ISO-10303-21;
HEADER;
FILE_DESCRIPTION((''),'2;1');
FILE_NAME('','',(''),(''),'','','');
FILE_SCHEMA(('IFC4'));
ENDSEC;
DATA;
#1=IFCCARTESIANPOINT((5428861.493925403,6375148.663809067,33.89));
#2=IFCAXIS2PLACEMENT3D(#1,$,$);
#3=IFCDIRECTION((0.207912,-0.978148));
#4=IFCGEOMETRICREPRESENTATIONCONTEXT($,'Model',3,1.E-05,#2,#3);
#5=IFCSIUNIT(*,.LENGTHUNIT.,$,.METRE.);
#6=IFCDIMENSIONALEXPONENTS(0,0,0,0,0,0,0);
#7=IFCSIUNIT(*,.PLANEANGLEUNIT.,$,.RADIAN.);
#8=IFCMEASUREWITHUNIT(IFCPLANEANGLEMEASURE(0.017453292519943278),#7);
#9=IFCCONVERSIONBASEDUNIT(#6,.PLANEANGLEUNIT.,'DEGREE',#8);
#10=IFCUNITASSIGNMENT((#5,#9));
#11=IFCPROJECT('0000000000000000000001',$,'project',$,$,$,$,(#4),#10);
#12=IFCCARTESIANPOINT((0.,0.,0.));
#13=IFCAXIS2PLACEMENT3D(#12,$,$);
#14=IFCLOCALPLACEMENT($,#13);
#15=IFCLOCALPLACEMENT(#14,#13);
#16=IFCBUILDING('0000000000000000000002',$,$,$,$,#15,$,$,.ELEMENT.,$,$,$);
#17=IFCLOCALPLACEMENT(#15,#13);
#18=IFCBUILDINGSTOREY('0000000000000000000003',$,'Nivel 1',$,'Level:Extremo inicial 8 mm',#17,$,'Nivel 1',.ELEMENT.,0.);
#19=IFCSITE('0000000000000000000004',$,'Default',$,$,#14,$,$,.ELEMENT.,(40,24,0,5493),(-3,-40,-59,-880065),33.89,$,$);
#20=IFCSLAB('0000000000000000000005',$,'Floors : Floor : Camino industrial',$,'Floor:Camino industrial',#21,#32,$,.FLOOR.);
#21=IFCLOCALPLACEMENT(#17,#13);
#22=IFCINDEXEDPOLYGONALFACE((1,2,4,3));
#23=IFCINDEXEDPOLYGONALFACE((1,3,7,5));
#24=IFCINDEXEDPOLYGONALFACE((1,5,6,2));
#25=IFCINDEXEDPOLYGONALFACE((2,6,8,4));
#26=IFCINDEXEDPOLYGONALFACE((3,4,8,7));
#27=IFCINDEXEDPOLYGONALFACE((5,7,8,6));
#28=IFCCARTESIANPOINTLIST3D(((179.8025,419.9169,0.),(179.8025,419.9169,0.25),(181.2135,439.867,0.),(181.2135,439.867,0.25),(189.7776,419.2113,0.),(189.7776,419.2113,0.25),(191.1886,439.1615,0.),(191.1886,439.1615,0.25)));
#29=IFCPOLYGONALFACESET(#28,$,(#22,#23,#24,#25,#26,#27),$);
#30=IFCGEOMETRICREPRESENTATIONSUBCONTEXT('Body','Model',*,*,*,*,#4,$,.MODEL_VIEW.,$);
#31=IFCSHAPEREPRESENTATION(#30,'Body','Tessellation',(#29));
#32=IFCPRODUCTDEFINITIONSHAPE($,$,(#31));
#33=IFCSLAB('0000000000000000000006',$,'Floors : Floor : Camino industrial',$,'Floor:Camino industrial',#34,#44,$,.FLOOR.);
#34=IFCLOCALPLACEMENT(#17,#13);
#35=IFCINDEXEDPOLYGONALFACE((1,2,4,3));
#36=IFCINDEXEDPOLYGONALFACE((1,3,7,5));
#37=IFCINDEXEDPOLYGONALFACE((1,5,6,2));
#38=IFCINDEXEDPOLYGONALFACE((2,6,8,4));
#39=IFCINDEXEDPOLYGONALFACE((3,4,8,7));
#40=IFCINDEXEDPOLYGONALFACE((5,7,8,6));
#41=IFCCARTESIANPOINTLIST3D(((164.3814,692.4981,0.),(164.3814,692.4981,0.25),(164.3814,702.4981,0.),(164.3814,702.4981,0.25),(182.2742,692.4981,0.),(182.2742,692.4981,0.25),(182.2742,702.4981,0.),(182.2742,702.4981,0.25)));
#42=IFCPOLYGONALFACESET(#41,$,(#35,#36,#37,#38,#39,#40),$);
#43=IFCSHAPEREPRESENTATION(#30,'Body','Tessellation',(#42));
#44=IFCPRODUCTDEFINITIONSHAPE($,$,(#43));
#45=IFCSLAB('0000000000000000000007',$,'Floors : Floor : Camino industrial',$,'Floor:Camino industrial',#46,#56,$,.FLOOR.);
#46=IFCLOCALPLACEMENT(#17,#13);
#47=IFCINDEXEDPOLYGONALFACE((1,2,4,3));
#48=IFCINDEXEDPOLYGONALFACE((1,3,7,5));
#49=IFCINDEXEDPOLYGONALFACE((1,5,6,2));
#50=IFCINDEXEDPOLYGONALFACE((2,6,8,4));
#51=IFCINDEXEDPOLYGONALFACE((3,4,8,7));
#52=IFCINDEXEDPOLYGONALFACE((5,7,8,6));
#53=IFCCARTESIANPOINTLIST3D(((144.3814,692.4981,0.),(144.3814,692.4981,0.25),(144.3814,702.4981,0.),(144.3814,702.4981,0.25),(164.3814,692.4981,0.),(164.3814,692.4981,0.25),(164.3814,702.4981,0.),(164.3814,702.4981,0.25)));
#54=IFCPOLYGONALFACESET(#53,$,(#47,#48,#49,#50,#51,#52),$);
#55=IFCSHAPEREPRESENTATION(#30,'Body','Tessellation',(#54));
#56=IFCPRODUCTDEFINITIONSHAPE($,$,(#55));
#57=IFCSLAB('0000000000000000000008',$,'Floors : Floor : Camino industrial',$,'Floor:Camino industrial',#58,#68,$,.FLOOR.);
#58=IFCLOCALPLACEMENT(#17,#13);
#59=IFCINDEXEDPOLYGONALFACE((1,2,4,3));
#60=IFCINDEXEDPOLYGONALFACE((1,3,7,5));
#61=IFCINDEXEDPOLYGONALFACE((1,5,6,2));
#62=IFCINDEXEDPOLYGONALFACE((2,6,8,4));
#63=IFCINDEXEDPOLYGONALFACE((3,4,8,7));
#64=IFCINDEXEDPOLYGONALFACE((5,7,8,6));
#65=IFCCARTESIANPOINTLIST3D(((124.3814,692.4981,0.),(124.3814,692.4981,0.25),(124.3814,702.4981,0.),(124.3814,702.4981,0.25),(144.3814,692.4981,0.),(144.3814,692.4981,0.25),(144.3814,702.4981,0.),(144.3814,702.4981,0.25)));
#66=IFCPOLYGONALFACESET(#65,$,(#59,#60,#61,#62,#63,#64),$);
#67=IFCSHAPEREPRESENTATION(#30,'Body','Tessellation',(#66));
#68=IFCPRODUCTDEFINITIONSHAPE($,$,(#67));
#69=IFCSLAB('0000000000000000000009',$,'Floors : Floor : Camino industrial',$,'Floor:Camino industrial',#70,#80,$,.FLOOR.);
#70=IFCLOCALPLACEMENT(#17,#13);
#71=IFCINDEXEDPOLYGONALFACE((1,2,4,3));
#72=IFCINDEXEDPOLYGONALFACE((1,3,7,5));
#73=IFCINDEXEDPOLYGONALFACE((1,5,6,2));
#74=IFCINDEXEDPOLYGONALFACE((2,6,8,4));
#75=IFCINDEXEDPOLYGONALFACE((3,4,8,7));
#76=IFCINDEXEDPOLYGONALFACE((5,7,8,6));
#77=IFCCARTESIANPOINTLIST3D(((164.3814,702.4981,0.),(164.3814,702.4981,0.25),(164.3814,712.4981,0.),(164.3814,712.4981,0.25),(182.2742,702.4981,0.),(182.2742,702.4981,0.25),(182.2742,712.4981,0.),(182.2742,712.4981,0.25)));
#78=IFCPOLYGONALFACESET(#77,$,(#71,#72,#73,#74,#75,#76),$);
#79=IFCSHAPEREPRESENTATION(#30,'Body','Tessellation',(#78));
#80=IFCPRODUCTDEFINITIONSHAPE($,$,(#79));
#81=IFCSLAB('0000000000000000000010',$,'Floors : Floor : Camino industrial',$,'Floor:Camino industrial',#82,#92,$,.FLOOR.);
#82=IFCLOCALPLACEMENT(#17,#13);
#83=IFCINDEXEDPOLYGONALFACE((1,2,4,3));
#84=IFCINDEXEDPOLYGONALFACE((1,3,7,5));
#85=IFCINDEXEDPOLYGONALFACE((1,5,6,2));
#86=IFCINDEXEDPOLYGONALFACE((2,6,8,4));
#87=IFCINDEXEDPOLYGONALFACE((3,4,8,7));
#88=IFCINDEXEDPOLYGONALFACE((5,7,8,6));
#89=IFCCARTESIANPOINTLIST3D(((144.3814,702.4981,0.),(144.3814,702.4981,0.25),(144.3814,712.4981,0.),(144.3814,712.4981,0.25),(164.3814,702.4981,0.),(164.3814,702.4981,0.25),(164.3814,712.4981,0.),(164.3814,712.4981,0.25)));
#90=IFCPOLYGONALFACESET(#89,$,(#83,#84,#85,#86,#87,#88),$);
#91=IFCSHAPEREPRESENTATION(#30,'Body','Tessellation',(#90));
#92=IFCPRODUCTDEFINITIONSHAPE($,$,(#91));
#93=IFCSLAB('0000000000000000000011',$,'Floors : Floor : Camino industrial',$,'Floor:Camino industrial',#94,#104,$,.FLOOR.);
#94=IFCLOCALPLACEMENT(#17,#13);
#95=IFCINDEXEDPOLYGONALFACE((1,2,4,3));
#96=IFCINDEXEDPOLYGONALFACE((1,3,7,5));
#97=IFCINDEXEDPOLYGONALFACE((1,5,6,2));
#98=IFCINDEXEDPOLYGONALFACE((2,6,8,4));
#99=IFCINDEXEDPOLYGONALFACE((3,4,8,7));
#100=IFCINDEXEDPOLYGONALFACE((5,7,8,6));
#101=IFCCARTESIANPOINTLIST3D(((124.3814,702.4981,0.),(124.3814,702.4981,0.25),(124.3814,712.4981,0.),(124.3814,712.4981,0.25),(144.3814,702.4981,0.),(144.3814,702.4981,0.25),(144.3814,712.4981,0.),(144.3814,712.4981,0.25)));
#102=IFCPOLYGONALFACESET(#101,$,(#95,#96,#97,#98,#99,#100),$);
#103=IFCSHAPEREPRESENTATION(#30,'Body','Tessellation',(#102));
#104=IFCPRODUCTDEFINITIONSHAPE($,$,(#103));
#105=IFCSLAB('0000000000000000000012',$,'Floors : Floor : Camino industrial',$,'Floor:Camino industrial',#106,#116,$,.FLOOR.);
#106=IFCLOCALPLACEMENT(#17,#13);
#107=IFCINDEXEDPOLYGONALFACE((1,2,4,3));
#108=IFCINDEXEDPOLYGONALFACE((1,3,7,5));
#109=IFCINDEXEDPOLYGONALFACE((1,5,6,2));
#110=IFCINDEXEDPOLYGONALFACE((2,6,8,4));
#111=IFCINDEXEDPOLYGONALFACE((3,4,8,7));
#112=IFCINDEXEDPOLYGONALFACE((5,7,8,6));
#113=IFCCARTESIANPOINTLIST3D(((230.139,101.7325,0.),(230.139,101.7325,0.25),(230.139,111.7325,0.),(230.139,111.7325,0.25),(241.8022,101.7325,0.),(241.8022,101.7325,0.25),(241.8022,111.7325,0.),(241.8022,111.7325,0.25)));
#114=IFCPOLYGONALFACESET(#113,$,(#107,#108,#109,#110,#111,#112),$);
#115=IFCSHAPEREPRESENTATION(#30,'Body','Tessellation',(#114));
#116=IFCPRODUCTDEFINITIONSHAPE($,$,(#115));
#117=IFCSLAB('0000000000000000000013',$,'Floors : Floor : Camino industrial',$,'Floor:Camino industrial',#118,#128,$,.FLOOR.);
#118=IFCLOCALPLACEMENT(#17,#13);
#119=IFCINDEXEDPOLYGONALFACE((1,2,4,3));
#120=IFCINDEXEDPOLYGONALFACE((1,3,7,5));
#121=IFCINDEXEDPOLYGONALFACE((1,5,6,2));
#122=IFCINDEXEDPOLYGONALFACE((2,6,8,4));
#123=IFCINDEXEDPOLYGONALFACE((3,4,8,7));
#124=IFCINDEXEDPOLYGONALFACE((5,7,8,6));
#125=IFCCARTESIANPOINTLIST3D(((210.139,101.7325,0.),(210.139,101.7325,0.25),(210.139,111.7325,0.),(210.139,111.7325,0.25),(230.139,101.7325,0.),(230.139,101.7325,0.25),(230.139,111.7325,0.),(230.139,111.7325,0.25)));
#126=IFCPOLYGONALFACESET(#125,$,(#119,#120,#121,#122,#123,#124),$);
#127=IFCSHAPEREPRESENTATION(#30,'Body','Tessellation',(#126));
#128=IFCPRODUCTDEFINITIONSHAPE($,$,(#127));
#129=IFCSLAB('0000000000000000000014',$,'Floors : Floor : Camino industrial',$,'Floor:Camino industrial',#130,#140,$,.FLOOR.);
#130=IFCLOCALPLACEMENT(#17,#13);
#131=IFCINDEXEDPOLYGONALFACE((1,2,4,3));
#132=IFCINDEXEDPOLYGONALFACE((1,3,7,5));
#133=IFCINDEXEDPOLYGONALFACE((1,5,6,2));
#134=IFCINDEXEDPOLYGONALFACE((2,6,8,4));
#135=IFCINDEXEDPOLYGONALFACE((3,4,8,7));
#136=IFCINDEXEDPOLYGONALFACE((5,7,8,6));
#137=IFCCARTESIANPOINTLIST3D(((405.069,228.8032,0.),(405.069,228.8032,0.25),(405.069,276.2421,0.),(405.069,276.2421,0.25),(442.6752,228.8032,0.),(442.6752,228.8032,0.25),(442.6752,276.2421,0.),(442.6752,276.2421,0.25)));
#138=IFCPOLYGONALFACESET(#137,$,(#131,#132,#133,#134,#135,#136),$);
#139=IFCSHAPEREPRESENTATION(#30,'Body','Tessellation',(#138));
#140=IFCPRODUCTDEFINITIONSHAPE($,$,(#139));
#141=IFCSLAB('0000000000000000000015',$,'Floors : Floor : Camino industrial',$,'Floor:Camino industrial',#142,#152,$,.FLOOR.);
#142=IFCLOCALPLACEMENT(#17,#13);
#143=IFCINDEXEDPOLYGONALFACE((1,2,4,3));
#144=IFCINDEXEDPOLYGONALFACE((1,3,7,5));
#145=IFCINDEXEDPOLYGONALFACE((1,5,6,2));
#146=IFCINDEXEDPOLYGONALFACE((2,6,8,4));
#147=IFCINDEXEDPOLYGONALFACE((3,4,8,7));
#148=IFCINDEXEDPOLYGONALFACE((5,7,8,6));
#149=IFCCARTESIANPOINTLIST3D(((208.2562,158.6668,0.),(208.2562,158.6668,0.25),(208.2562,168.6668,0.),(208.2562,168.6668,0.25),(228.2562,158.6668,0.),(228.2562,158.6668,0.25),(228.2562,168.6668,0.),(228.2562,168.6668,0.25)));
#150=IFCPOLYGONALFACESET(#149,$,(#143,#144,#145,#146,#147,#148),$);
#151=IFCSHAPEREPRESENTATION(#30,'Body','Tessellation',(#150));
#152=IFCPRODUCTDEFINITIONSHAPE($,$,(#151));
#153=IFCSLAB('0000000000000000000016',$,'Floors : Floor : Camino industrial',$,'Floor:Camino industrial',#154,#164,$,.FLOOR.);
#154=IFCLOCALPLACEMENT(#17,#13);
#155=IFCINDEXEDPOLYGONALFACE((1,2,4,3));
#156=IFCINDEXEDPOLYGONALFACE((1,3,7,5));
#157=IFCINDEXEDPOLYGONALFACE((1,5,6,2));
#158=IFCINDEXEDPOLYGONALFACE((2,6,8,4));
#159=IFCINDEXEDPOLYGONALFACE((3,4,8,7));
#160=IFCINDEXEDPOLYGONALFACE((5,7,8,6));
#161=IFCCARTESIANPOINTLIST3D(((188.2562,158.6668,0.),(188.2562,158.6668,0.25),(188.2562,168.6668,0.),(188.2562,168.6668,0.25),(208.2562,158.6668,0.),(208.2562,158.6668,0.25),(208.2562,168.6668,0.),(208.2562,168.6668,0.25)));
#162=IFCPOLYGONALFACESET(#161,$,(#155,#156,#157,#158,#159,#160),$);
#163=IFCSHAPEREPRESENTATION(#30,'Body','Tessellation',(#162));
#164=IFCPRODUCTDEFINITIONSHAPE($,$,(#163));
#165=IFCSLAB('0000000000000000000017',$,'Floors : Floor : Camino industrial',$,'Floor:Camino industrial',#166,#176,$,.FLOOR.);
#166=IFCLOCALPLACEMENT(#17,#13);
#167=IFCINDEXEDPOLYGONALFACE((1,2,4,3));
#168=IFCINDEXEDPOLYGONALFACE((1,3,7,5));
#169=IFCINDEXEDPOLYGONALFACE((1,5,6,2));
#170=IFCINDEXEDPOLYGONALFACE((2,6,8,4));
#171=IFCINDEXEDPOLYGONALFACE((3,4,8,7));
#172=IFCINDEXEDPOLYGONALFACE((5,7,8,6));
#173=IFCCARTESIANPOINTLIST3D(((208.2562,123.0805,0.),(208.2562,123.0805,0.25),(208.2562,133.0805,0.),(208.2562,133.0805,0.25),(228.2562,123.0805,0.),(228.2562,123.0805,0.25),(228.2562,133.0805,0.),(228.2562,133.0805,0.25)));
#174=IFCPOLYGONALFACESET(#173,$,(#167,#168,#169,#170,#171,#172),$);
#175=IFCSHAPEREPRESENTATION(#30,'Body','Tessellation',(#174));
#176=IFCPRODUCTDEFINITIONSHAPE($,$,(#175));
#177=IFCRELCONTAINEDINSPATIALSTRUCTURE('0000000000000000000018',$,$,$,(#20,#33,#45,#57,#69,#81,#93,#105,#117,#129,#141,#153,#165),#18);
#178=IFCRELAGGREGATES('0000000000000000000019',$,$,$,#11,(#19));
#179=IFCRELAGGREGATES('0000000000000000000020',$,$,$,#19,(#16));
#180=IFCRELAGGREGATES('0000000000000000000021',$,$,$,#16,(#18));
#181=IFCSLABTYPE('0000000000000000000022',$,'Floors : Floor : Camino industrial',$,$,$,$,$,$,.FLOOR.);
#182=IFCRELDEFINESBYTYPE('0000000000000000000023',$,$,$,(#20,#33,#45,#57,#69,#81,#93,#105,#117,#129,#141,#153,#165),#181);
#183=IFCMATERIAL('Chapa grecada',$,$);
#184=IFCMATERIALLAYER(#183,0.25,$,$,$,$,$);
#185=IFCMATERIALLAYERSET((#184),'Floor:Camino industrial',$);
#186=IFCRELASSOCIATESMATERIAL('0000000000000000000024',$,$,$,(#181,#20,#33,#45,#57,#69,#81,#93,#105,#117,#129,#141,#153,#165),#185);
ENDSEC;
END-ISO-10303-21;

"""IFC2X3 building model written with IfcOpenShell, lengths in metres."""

from ifc_helpers import new_model, entity, si_unit, converted_unit, direction, frame, frame_2d, origin, origin_2d_with_axis, place, context, subcontext, project, spatial, rectangle, extrude, material, layer, layer_set, layer_usage, type_object, element, save


model = new_model("IFC2X3")

# Units and contexts
model_context = context("Model", 3, precision=1e-05, world=frame((5428861.493925403, 6375148.663809067, 33.89)), true_north=direction((0.207912, -0.978148)))
body_context = subcontext(model_context, "Body", "Model", "MODEL_VIEW")
ifc_project = project(units=[si_unit("LENGTHUNIT", "METRE"), converted_unit("PLANEANGLEUNIT", "DEGREE", entity("IfcPlaneAngleMeasure", 0.017453292519943278), si_unit("PLANEANGLEUNIT", "RADIAN"), dimensions=[0, 0, 0, 0, 0, 0, 0])], contexts=[model_context])

# Site, building, storey
site_placement = place(None, origin())
site = spatial("IfcSite", under=ifc_project, at=site_placement, Name="Default", CompositionType="ELEMENT", RefLatitude=(40, 24, 0, 5493), RefLongitude=(-3, -40, -59, -880065), RefElevation=33.89)
building_placement = place(site_placement, origin())
building = spatial("IfcBuilding", under=site, at=building_placement, CompositionType="ELEMENT")
storey_placement = place(building_placement, origin())
storey = spatial("IfcBuildingStorey", under=building, at=storey_placement, Name="Nivel 1", ObjectType="Level:Extremo inicial 8 mm", LongName="Nivel 1", CompositionType="ELEMENT", Elevation=0.0)

# Slabs
ifc_material_1 = material(Name="Chapa grecada")
ifc_layer_1 = layer(ifc_material_1, 0.25)
ifc_layer_set_1 = layer_set([ifc_layer_1], Name="Floor:Camino industrial")
slab_type = type_object("IfcSlabType", Name="Floors : Floor : Camino industrial", PredefinedType="FLOOR", material=ifc_layer_set_1)
ifc_layer_usage_1 = layer_usage(ifc_layer_set_1, "AXIS3", "POSITIVE", 0.0)
slab_1_placement = place(storey_placement, origin())
element("IfcSlab", 1, at=slab_1_placement, inside=storey, type_object=slab_type, material=ifc_layer_usage_1, Name="Floors : Floor : Camino industrial", ObjectType="Floor:Camino industrial", PredefinedType="FLOOR", context=body_context, shape_type="SweptSolid", body=[
    extrude(rectangle(XDim=20.0, YDim=10.0, at=frame_2d((0.0, 0.0), x_axis=(1.0, 0.0))), frame((185.4955, 429.5392, 0.25), z_axis=(0.0, 0.0, -1.0), x_axis=(-0.070551, -0.997508, 0.0)), (0.0, 0.0, 1.0), 0.25),
])
ifc_layer_usage_2 = layer_usage(ifc_layer_set_1, "AXIS3", "POSITIVE", 0.0)
slab_2_placement = place(storey_placement, origin())
element("IfcSlab", 2, at=slab_2_placement, inside=storey, type_object=slab_type, material=ifc_layer_usage_2, Name="Floors : Floor : Camino industrial", ObjectType="Floor:Camino industrial", PredefinedType="FLOOR", context=body_context, shape_type="SweptSolid", body=[
    extrude(rectangle(XDim=10.0, YDim=17.8928, at=frame_2d((0.0, 0.0), x_axis=(1.0, 0.0))), frame((173.3278, 697.4981, 0.25), z_axis=(0.0, 0.0, -1.0), x_axis=(0.0, 1.0, 0.0)), (0.0, 0.0, 1.0), 0.25),
])
ifc_layer_usage_3 = layer_usage(ifc_layer_set_1, "AXIS3", "POSITIVE", 0.0)
slab_3_placement = place(storey_placement, origin())
element("IfcSlab", 3, at=slab_3_placement, inside=storey, type_object=slab_type, material=ifc_layer_usage_3, Name="Floors : Floor : Camino industrial", ObjectType="Floor:Camino industrial", PredefinedType="FLOOR", context=body_context, shape_type="SweptSolid", body=[
    extrude(rectangle(XDim=10.0, YDim=20.0, at=frame_2d((0.0, 0.0), x_axis=(1.0, 0.0))), frame((154.3814, 697.4981, 0.25), z_axis=(0.0, 0.0, -1.0), x_axis=(0.0, 1.0, 0.0)), (0.0, 0.0, 1.0), 0.25),
])
ifc_layer_usage_4 = layer_usage(ifc_layer_set_1, "AXIS3", "POSITIVE", 0.0)
slab_4_placement = place(storey_placement, origin())
element("IfcSlab", 4, at=slab_4_placement, inside=storey, type_object=slab_type, material=ifc_layer_usage_4, Name="Floors : Floor : Camino industrial", ObjectType="Floor:Camino industrial", PredefinedType="FLOOR", context=body_context, shape_type="SweptSolid", body=[
    extrude(rectangle(XDim=10.0, YDim=20.0, at=frame_2d((0.0, 0.0), x_axis=(1.0, 0.0))), frame((134.3814, 697.4981, 0.25), z_axis=(0.0, 0.0, -1.0), x_axis=(0.0, 1.0, 0.0)), (0.0, 0.0, 1.0), 0.25),
])
ifc_layer_usage_5 = layer_usage(ifc_layer_set_1, "AXIS3", "POSITIVE", 0.0)
slab_5_placement = place(storey_placement, origin())
element("IfcSlab", 5, at=slab_5_placement, inside=storey, type_object=slab_type, material=ifc_layer_usage_5, Name="Floors : Floor : Camino industrial", ObjectType="Floor:Camino industrial", PredefinedType="FLOOR", context=body_context, shape_type="SweptSolid", body=[
    extrude(rectangle(XDim=10.0, YDim=17.8928, at=frame_2d((0.0, 0.0), x_axis=(1.0, 0.0))), frame((173.3278, 707.4981, 0.25), z_axis=(0.0, 0.0, -1.0), x_axis=(0.0, 1.0, 0.0)), (0.0, 0.0, 1.0), 0.25),
])
ifc_layer_usage_6 = layer_usage(ifc_layer_set_1, "AXIS3", "POSITIVE", 0.0)
slab_6_placement = place(storey_placement, origin())
element("IfcSlab", 6, at=slab_6_placement, inside=storey, type_object=slab_type, material=ifc_layer_usage_6, Name="Floors : Floor : Camino industrial", ObjectType="Floor:Camino industrial", PredefinedType="FLOOR", context=body_context, shape_type="SweptSolid", body=[
    extrude(rectangle(XDim=10.0, YDim=20.0, at=frame_2d((0.0, 0.0), x_axis=(1.0, 0.0))), frame((154.3814, 707.4981, 0.25), z_axis=(0.0, 0.0, -1.0), x_axis=(0.0, 1.0, 0.0)), (0.0, 0.0, 1.0), 0.25),
])
ifc_layer_usage_7 = layer_usage(ifc_layer_set_1, "AXIS3", "POSITIVE", 0.0)
slab_7_placement = place(storey_placement, origin())
element("IfcSlab", 7, at=slab_7_placement, inside=storey, type_object=slab_type, material=ifc_layer_usage_7, Name="Floors : Floor : Camino industrial", ObjectType="Floor:Camino industrial", PredefinedType="FLOOR", context=body_context, shape_type="SweptSolid", body=[
    extrude(rectangle(XDim=10.0, YDim=20.0, at=frame_2d((0.0, 0.0), x_axis=(1.0, 0.0))), frame((134.3814, 707.4981, 0.25), z_axis=(0.0, 0.0, -1.0), x_axis=(0.0, 1.0, 0.0)), (0.0, 0.0, 1.0), 0.25),
])
ifc_layer_usage_8 = layer_usage(ifc_layer_set_1, "AXIS3", "POSITIVE", 0.0)
slab_8_placement = place(storey_placement, origin())
element("IfcSlab", 8, at=slab_8_placement, inside=storey, type_object=slab_type, material=ifc_layer_usage_8, Name="Floors : Floor : Camino industrial", ObjectType="Floor:Camino industrial", PredefinedType="FLOOR", context=body_context, shape_type="SweptSolid", body=[
    extrude(rectangle(XDim=10.0, YDim=11.6632, at=origin_2d_with_axis()), frame((235.9706, 106.7325, 0.25), z_axis=(0.0, 0.0, -1.0), x_axis=(0.0, 1.0, 0.0)), (0.0, 0.0, 1.0), 0.25),
])
ifc_layer_usage_9 = layer_usage(ifc_layer_set_1, "AXIS3", "POSITIVE", 0.0)
slab_9_placement = place(storey_placement, origin())
element("IfcSlab", 9, at=slab_9_placement, inside=storey, type_object=slab_type, material=ifc_layer_usage_9, Name="Floors : Floor : Camino industrial", ObjectType="Floor:Camino industrial", PredefinedType="FLOOR", context=body_context, shape_type="SweptSolid", body=[
    extrude(rectangle(XDim=10.0, YDim=20.0, at=origin_2d_with_axis()), frame((220.139, 106.7325, 0.25), z_axis=(0.0, 0.0, -1.0), x_axis=(0.0, 1.0, 0.0)), (0.0, 0.0, 1.0), 0.25),
])
ifc_layer_usage_10 = layer_usage(ifc_layer_set_1, "AXIS3", "POSITIVE", 0.0)
slab_10_placement = place(storey_placement, origin())
element("IfcSlab", 10, at=slab_10_placement, inside=storey, type_object=slab_type, material=ifc_layer_usage_10, Name="Floors : Floor : Camino industrial", ObjectType="Floor:Camino industrial", PredefinedType="FLOOR", context=body_context, shape_type="SweptSolid", body=[
    extrude(rectangle(XDim=47.4389, YDim=37.6062, at=origin_2d_with_axis()), frame((423.8721, 252.5226, 0.25), z_axis=(0.0, 0.0, -1.0), x_axis=(0.0, 1.0, 0.0)), (0.0, 0.0, 1.0), 0.25),
])
ifc_layer_usage_11 = layer_usage(ifc_layer_set_1, "AXIS3", "POSITIVE", 0.0)
slab_11_placement = place(storey_placement, origin())
element("IfcSlab", 11, at=slab_11_placement, inside=storey, type_object=slab_type, material=ifc_layer_usage_11, Name="Floors : Floor : Camino industrial", ObjectType="Floor:Camino industrial", PredefinedType="FLOOR", context=body_context, shape_type="SweptSolid", body=[
    extrude(rectangle(XDim=10.0, YDim=20.0, at=frame_2d((0.0, 0.0), x_axis=(1.0, 0.0))), frame((218.2562, 163.6668, 0.25), z_axis=(0.0, 0.0, -1.0), x_axis=(0.0, 1.0, 0.0)), (0.0, 0.0, 1.0), 0.25),
])
ifc_layer_usage_12 = layer_usage(ifc_layer_set_1, "AXIS3", "POSITIVE", 0.0)
slab_12_placement = place(storey_placement, origin())
element("IfcSlab", 12, at=slab_12_placement, inside=storey, type_object=slab_type, material=ifc_layer_usage_12, Name="Floors : Floor : Camino industrial", ObjectType="Floor:Camino industrial", PredefinedType="FLOOR", context=body_context, shape_type="SweptSolid", body=[
    extrude(rectangle(XDim=10.0, YDim=20.0, at=frame_2d((0.0, 0.0), x_axis=(1.0, 0.0))), frame((198.2562, 163.6668, 0.25), z_axis=(0.0, 0.0, -1.0), x_axis=(0.0, 1.0, 0.0)), (0.0, 0.0, 1.0), 0.25),
])
ifc_layer_usage_13 = layer_usage(ifc_layer_set_1, "AXIS3", "POSITIVE", 0.0)
slab_13_placement = place(storey_placement, origin())
element("IfcSlab", 13, at=slab_13_placement, inside=storey, type_object=slab_type, material=ifc_layer_usage_13, Name="Floors : Floor : Camino industrial", ObjectType="Floor:Camino industrial", PredefinedType="FLOOR", context=body_context, shape_type="SweptSolid", body=[
    extrude(rectangle(XDim=10.0, YDim=20.0, at=frame_2d((0.0, 0.0), x_axis=(1.0, 0.0))), frame((218.2562, 128.0805, 0.25), z_axis=(0.0, 0.0, -1.0), x_axis=(0.0, 1.0, 0.0)), (0.0, 0.0, 1.0), 0.25),
])

save(model, "model.ifc")
